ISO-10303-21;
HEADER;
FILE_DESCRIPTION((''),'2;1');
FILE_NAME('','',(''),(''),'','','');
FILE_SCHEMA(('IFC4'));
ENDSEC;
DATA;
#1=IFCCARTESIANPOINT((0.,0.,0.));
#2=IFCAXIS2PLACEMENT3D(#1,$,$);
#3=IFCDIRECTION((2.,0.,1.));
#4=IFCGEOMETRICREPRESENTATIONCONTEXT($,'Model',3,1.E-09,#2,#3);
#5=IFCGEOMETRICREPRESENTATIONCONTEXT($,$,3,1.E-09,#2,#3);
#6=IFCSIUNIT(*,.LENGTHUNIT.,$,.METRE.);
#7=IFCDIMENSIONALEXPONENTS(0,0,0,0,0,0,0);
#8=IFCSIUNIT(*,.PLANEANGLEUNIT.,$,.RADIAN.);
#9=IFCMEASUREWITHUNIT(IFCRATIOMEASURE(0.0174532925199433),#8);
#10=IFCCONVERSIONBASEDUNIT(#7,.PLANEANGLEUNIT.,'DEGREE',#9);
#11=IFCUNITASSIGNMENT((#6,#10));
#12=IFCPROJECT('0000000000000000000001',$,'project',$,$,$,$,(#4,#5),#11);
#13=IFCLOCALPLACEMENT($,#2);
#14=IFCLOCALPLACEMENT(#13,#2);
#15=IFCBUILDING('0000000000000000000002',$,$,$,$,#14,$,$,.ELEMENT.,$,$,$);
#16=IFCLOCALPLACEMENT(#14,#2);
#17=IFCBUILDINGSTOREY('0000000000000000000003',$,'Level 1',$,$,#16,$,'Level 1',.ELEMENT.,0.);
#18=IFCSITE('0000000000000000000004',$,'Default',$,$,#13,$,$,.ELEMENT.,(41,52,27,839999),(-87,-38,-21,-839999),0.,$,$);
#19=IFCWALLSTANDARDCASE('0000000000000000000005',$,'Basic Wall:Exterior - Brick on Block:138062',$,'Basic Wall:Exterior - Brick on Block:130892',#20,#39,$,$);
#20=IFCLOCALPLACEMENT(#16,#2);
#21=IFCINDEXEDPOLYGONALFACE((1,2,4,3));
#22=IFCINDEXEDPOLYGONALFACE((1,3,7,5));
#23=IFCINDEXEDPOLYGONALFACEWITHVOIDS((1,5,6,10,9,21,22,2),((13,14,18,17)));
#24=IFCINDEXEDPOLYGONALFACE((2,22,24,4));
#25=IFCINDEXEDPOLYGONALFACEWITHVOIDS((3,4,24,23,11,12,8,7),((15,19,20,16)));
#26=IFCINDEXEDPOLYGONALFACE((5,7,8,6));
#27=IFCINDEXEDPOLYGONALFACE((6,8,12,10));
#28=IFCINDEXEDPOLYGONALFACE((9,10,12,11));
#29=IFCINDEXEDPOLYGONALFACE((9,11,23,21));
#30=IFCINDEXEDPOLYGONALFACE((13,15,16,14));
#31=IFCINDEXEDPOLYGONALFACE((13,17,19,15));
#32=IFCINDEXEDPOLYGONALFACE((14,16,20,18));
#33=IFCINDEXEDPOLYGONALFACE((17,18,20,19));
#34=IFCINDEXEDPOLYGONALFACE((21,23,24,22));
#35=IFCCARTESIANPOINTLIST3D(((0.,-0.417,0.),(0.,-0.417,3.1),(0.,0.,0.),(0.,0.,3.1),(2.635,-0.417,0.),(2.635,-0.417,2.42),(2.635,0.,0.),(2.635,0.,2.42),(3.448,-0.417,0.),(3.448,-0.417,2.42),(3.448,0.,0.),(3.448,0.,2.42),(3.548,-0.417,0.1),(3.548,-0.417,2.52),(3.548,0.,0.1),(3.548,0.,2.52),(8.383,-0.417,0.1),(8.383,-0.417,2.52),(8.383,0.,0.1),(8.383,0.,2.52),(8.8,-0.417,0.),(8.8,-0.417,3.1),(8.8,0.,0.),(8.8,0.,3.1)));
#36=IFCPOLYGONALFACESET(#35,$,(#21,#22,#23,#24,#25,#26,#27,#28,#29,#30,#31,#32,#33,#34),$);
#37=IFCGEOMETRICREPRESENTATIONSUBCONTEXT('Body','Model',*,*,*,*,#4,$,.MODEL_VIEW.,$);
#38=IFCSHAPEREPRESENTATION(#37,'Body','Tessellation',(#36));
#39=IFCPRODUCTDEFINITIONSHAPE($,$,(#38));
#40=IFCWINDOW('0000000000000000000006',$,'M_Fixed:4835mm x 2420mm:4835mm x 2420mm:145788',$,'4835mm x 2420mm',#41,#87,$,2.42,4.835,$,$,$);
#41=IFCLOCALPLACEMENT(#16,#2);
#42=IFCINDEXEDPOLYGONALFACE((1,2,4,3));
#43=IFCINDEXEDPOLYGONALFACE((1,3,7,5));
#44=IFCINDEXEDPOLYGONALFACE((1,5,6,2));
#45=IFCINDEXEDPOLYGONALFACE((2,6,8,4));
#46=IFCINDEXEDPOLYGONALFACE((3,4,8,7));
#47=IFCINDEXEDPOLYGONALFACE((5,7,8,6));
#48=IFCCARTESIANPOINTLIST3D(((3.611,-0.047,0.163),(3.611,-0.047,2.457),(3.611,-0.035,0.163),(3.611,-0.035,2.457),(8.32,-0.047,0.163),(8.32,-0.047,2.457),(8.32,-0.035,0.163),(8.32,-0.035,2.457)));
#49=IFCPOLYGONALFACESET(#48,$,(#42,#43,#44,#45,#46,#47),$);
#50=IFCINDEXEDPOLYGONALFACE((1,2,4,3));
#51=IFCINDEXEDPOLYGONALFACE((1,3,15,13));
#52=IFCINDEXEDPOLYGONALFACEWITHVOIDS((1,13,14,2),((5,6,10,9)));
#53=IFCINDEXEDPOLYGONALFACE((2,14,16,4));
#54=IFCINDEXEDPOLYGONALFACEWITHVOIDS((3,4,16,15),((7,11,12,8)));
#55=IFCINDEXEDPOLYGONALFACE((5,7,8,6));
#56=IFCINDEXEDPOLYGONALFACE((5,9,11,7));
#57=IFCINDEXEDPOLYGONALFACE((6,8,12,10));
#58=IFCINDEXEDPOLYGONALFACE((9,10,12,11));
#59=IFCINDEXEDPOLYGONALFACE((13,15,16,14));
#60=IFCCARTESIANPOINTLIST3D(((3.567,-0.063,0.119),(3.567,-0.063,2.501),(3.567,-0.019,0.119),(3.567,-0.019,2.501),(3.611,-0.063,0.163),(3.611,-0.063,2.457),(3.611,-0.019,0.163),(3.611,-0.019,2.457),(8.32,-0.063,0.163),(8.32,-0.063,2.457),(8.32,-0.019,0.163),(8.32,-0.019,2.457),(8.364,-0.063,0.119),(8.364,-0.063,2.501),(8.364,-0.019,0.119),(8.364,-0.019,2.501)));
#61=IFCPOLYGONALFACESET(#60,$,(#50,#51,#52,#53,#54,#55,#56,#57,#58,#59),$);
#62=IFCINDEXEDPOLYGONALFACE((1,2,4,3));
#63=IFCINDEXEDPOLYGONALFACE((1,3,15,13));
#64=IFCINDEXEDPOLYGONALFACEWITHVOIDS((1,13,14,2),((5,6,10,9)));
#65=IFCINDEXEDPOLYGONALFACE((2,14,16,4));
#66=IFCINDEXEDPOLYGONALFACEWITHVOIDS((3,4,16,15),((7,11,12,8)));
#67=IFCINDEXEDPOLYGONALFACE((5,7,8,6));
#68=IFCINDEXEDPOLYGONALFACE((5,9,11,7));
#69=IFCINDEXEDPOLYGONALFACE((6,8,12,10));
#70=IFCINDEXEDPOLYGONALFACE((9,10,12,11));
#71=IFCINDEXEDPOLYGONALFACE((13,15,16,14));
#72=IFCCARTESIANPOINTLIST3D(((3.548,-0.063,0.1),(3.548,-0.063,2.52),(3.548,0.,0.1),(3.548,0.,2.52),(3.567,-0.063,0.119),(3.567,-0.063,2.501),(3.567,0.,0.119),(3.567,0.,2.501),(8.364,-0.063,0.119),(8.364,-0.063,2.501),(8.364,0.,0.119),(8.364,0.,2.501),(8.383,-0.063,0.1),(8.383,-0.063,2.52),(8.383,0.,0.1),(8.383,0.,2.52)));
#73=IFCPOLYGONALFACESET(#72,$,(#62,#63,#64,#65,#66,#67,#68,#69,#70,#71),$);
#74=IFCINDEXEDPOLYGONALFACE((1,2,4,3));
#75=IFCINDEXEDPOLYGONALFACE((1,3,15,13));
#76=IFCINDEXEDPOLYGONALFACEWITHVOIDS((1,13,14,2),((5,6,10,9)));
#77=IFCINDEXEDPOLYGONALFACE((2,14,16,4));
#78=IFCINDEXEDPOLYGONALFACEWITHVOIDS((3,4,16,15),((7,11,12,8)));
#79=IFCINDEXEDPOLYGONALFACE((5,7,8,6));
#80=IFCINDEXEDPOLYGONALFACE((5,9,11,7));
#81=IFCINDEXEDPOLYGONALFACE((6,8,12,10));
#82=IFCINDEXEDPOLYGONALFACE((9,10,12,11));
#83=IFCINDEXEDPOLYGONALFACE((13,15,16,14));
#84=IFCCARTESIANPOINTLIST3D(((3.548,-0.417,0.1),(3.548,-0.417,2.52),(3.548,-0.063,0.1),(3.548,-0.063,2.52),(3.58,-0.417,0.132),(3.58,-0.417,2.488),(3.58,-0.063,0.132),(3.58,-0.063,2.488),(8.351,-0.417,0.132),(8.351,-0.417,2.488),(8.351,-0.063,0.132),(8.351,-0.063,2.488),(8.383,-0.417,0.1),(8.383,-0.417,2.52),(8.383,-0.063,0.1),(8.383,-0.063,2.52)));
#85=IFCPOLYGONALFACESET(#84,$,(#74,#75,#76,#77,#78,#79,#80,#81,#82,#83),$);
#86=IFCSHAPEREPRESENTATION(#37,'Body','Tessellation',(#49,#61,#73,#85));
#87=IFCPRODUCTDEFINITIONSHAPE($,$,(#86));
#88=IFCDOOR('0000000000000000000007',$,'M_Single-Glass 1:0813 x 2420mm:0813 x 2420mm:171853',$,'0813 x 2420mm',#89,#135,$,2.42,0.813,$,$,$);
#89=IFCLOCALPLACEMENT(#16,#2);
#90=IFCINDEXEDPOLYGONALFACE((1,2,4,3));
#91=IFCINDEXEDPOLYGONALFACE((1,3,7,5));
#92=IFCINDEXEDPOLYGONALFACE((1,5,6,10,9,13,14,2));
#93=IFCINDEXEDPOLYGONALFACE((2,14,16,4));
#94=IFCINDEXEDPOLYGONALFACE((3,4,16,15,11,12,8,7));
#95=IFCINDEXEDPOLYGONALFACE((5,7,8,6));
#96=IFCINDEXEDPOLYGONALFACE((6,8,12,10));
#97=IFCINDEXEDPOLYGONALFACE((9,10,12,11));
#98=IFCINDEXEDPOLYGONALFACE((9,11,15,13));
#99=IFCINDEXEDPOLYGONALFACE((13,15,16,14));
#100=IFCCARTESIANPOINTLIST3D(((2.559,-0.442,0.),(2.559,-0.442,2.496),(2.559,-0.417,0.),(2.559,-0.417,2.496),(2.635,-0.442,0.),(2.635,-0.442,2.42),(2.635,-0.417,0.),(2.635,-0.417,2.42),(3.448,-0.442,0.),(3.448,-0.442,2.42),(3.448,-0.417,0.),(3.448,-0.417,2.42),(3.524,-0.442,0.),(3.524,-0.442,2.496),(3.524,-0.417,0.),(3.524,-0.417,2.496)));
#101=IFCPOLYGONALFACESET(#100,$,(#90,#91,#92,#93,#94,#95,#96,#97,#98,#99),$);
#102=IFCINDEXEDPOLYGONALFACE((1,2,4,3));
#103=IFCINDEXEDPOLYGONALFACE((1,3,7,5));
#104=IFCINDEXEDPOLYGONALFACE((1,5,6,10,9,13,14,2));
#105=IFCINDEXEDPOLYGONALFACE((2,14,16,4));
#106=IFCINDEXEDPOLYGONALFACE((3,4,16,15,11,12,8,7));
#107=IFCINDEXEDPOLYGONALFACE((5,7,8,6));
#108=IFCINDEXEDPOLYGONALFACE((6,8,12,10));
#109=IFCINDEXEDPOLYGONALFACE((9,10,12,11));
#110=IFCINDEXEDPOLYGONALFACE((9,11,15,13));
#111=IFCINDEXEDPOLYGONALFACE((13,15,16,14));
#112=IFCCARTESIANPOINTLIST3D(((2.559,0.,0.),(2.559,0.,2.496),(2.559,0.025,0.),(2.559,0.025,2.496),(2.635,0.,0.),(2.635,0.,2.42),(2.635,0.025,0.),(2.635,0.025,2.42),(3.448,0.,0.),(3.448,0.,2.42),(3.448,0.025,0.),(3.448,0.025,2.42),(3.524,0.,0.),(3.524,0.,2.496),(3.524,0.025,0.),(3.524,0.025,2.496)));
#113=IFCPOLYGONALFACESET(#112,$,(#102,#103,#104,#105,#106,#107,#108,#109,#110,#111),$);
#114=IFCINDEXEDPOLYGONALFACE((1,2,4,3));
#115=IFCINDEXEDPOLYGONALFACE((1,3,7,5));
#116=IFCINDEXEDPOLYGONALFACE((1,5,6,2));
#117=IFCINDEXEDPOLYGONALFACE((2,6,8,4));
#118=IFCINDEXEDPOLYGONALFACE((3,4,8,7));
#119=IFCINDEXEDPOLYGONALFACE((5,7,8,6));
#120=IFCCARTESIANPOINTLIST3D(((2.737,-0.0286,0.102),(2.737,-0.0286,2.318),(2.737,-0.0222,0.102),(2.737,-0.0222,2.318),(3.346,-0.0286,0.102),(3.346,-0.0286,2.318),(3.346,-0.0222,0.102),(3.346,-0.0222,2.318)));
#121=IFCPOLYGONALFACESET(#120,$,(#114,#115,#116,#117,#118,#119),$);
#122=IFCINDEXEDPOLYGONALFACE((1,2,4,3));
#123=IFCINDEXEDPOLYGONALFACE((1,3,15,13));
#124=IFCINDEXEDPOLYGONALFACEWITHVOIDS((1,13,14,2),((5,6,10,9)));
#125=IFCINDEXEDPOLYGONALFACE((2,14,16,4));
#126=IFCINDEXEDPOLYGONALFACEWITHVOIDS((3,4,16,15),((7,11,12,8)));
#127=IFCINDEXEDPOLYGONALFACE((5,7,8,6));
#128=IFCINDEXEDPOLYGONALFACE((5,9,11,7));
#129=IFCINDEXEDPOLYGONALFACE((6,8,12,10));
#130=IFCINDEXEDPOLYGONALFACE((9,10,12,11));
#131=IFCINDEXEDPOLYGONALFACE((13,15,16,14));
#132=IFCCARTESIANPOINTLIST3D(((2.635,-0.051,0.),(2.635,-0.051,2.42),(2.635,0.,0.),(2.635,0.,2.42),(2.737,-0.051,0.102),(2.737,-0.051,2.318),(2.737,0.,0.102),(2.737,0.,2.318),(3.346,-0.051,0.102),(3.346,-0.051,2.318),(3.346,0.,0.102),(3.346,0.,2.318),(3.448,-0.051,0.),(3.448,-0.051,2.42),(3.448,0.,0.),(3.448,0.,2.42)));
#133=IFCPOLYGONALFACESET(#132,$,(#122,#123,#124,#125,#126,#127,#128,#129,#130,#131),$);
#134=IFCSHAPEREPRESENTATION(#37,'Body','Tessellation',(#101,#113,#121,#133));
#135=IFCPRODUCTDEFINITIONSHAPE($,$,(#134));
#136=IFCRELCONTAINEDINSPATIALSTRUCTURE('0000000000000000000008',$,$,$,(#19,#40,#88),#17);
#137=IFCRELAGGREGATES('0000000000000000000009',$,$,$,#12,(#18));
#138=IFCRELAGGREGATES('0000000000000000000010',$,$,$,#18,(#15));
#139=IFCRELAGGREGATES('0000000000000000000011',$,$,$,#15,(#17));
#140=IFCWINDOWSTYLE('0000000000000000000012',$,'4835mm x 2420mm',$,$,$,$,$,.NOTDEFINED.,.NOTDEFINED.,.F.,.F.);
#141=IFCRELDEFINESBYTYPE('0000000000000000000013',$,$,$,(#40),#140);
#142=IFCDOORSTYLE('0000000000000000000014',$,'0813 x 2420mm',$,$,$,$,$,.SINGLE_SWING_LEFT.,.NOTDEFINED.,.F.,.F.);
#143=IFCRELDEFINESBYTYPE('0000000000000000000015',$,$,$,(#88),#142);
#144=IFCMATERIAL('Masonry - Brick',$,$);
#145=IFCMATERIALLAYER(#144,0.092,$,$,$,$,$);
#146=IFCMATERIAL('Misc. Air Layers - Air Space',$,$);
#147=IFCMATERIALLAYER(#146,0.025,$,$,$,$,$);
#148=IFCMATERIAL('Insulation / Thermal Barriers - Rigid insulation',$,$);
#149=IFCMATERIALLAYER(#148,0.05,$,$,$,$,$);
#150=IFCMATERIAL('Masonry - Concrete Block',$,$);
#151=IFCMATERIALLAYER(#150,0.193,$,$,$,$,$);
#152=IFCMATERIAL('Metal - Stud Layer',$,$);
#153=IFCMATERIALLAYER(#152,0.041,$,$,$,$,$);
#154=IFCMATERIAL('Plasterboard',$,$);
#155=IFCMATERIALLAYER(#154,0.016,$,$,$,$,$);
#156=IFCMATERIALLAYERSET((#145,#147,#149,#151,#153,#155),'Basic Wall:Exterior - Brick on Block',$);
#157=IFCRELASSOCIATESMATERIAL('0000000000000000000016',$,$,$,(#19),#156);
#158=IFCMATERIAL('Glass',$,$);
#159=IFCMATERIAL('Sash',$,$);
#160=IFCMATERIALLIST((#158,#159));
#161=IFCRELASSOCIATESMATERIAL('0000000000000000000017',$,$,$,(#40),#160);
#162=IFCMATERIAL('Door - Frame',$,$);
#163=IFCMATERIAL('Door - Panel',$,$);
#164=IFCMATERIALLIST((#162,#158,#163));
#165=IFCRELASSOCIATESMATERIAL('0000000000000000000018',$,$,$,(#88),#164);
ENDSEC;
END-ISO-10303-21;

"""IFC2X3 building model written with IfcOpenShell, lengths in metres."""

from ifc_helpers import new_model, entity, si_unit, converted_unit, direction, frame, frame_2d, origin, origin_2d_with_axis, place, context, subcontext, project, spatial, polyline, rectangle, outline, extrude, source, transform, mapped, material, material_list, layer, layer_set, layer_usage, type_object, type_shapes, element, fill, save


model = new_model("IFC2X3")

# Units and contexts
model_context = context("Model", 3, precision=1e-09, world=origin(), true_north=direction((2.0, 0.0, 1.0)))
context_of_model = context(None, 3, precision=1e-09, world=origin(), true_north=direction((2.0, 0.0, 1.0)))
body_context = subcontext(model_context, "Body", "Model", "MODEL_VIEW")
ifc_project = project(units=[si_unit("LENGTHUNIT", "METRE"), converted_unit("PLANEANGLEUNIT", "DEGREE", entity("IfcRatioMeasure", 0.0174532925199433), si_unit("PLANEANGLEUNIT", "RADIAN"), dimensions=[0, 0, 0, 0, 0, 0, 0])], contexts=[model_context, context_of_model])

# Site, building, storey
site_placement = place(None, origin())
site = spatial("IfcSite", under=ifc_project, at=site_placement, Name="Default", CompositionType="ELEMENT", RefLatitude=(41, 52, 27, 839999), RefLongitude=(-87, -38, -21, -839999), RefElevation=0.0)
building_placement = place(site_placement, origin())
building = spatial("IfcBuilding", under=site, at=building_placement, CompositionType="ELEMENT")
storey_placement = place(building_placement, origin())
storey = spatial("IfcBuildingStorey", under=building, at=storey_placement, Name="Level 1", LongName="Level 1", CompositionType="ELEMENT", Elevation=0.0)

# Wall, openings, window, door
ifc_material_1 = material(Name="Masonry - Brick")
ifc_layer_1 = layer(ifc_material_1, 0.092)
ifc_material_2 = material(Name="Misc. Air Layers - Air Space")
ifc_layer_2 = layer(ifc_material_2, 0.025)
ifc_material_3 = material(Name="Insulation / Thermal Barriers - Rigid insulation")
ifc_layer_3 = layer(ifc_material_3, 0.05)
ifc_material_4 = material(Name="Masonry - Concrete Block")
ifc_layer_4 = layer(ifc_material_4, 0.193)
ifc_material_5 = material(Name="Metal - Stud Layer")
ifc_layer_5 = layer(ifc_material_5, 0.041)
ifc_material_6 = material(Name="Plasterboard")
ifc_layer_6 = layer(ifc_material_6, 0.016)
ifc_layer_set_1 = layer_set([ifc_layer_1, ifc_layer_2, ifc_layer_3, ifc_layer_4, ifc_layer_5, ifc_layer_6], Name="Basic Wall:Exterior - Brick on Block")
ifc_layer_usage_1 = layer_usage(ifc_layer_set_1, "AXIS2", "NEGATIVE", 0.2085)
wall_1_placement = place(storey_placement, frame((0.0, -0.2085, 0.0)))
wall_1 = element("IfcWallStandardCase", 1, at=wall_1_placement, inside=storey, material=ifc_layer_usage_1, Name="Basic Wall:Exterior - Brick on Block:138062", ObjectType="Basic Wall:Exterior - Brick on Block:130892", context=body_context, shape_type="SweptSolid", body=[
    extrude(rectangle(XDim=8.8, YDim=0.417, at=frame_2d((4.4, 0.0), x_axis=(-1.0, 0.0))), origin(), (0.0, 0.0, 1.0), 3.1),
])
opening_1_placement = place(wall_1_placement, frame((3.548, -0.2085, 0.1)))
opening_1 = element("IfcOpeningElement", 2, at=opening_1_placement, cuts=wall_1, ObjectType="Opening", context=body_context, shape_type="SweptSolid", body=[
    extrude(rectangle(XDim=2.42, YDim=4.835, at=frame_2d((1.21, 2.4175), x_axis=(1.0, 0.0))), frame((0.0, 0.0, 0.0), z_axis=(0.0, 1.0, 0.0), x_axis=(0.0, 0.0, 1.0)), (0.0, 0.0, 1.0), 0.417),
])
opening_2_placement = place(wall_1_placement, frame((2.635, -0.2085, 0.0)))
opening_2 = element("IfcOpeningElement", 3, at=opening_2_placement, cuts=wall_1, ObjectType="Opening", context=body_context, shape_type="SweptSolid", body=[
    extrude(rectangle(XDim=0.813, YDim=2.42, at=frame_2d((1.21, 0.4065), x_axis=(0.0, -1.0))), frame((0.0, 0.0, 0.0), z_axis=(0.0, 1.0, 0.0), x_axis=(0.0, 0.0, 1.0)), (0.0, 0.0, 1.0), 0.417),
])
ifc_material_7 = material(Name="Glass")
ifc_material_8 = material(Name="Sash")
ifc_material_list_1 = material_list([ifc_material_7, ifc_material_8])
window_style_1 = type_object("IfcWindowStyle", Name="4835mm x 2420mm", ConstructionType="NOTDEFINED", OperationType="NOTDEFINED", ParameterTakesPrecedence=False, Sizeable=False)
shared_shape_1 = source(origin(), body_context, "Body", "SweptSolid", [
    extrude(rectangle(XDim=0.012, YDim=4.709, at=origin_2d_with_axis()), frame((2.4175, 0.376, 0.063), z_axis=(0.0, 0.0, 1.0), x_axis=(0.0, -1.0, 0.0)), (0.0, 0.0, 1.0), 2.294),
    extrude(outline(polyline([(-2.3985, -1.191), (2.3985, -1.191), (2.3985, 1.191), (-2.3985, 1.191), (-2.3985, -1.191)]), holes=[polyline([(-2.3545, -1.147), (-2.3545, 1.147), (2.3545, 1.147), (2.3545, -1.147), (-2.3545, -1.147)])]), frame((2.4175, 0.354, 1.21), z_axis=(0.0, 1.0, 0.0), x_axis=(1.0, 0.0, 0.0)), (0.0, 0.0, 1.0), 0.044),
    extrude(outline(polyline([(-2.4175, -1.21), (2.4175, -1.21), (2.4175, 1.21), (-2.4175, 1.21), (-2.4175, -1.21)]), holes=[polyline([(-2.3985, -1.191), (-2.3985, 1.191), (2.3985, 1.191), (2.3985, -1.191), (-2.3985, -1.191)])]), frame((2.4175, 0.354, 1.21), z_axis=(0.0, 1.0, 0.0), x_axis=(1.0, 0.0, 0.0)), (0.0, 0.0, 1.0), 0.063),
    extrude(outline(polyline([(-2.4175, -1.21), (2.4175, -1.21), (2.4175, 1.21), (-2.4175, 1.21), (-2.4175, -1.21)]), holes=[polyline([(-2.3855, -1.178), (-2.3855, 1.178), (2.3855, 1.178), (2.3855, -1.178), (-2.3855, -1.178)])]), frame((2.4175, 0.0, 1.21), z_axis=(0.0, 1.0, 0.0), x_axis=(1.0, 0.0, 0.0)), (0.0, 0.0, 1.0), 0.354),
])
type_shapes(window_style_1, [shared_shape_1])
window_1_placement = place(opening_1_placement, origin())
window_1 = element("IfcWindow", 4, at=window_1_placement, inside=storey, type_object=window_style_1, material=ifc_material_list_1, Name="M_Fixed:4835mm x 2420mm:4835mm x 2420mm:145788", ObjectType="4835mm x 2420mm", OverallHeight=2.42, OverallWidth=4.835, context=body_context, shape_type="MappedRepresentation", body=[
    mapped(shared_shape_1, transform((0.0, 0.0, 0.0), scale=1.0)),
])
fill(opening_1, window_1)
ifc_material_9 = material(Name="Door - Frame")
ifc_material_10 = material(Name="Door - Panel")
ifc_material_list_2 = material_list([ifc_material_9, ifc_material_7, ifc_material_10])
door_style_1 = type_object("IfcDoorStyle", Name="0813 x 2420mm", ConstructionType="NOTDEFINED", OperationType="SINGLE_SWING_LEFT", ParameterTakesPrecedence=False, Sizeable=False)
shared_shape_2 = source(origin(), body_context, "Body", "SweptSolid", [
    extrude(outline(polyline([(-0.4065, -1.191), (-0.4065, 1.229), (-0.4825, 1.229), (-0.4825, -1.267), (0.4825, -1.267), (0.4825, 1.229), (0.4065, 1.229), (0.4065, -1.191), (-0.4065, -1.191)])), frame((0.4065, 0.0, 1.229), z_axis=(0.0, 1.0, 0.0), x_axis=(1.0, 0.0, 0.0)), (0.0, 0.0, -1.0), 0.025),
    extrude(outline(polyline([(-0.4065, -1.191), (-0.4065, 1.229), (-0.4825, 1.229), (-0.4825, -1.267), (0.4825, -1.267), (0.4825, 1.229), (0.4065, 1.229), (0.4065, -1.191), (-0.4065, -1.191)])), frame((0.4065, 0.442, 1.229), z_axis=(0.0, 1.0, 0.0), x_axis=(1.0, 0.0, 0.0)), (0.0, 0.0, -1.0), 0.025),
    extrude(rectangle(XDim=0.609, YDim=0.0064, at=frame_2d((0.0, 0.0), x_axis=(1.0, 0.0))), frame((0.4065, 0.3916, 0.102)), (0.0, 0.0, 1.0), 2.216),
    extrude(outline(polyline([(-1.21, -0.4065), (1.21, -0.4065), (1.21, 0.4065), (-1.21, 0.4065), (-1.21, -0.4065)]), holes=[polyline([(-1.108, 0.3045), (1.108, 0.3045), (1.108, -0.3045), (-1.108, -0.3045), (-1.108, 0.3045)])]), frame((0.4065, 0.417, 1.21), z_axis=(0.0, -1.0, 0.0), x_axis=(0.0, 0.0, -1.0)), (0.0, 0.0, 1.0), 0.051),
])
type_shapes(door_style_1, [shared_shape_2])
door_1_placement = place(opening_2_placement, origin())
door_1 = element("IfcDoor", 5, at=door_1_placement, inside=storey, type_object=door_style_1, material=ifc_material_list_2, Name="M_Single-Glass 1:0813 x 2420mm:0813 x 2420mm:171853", ObjectType="0813 x 2420mm", OverallHeight=2.42, OverallWidth=0.813, context=body_context, shape_type="MappedRepresentation", body=[
    mapped(shared_shape_2, transform((0.0, 0.0, 0.0), scale=1.0)),
])
fill(opening_2, door_1)

save(model, "model.ifc")
